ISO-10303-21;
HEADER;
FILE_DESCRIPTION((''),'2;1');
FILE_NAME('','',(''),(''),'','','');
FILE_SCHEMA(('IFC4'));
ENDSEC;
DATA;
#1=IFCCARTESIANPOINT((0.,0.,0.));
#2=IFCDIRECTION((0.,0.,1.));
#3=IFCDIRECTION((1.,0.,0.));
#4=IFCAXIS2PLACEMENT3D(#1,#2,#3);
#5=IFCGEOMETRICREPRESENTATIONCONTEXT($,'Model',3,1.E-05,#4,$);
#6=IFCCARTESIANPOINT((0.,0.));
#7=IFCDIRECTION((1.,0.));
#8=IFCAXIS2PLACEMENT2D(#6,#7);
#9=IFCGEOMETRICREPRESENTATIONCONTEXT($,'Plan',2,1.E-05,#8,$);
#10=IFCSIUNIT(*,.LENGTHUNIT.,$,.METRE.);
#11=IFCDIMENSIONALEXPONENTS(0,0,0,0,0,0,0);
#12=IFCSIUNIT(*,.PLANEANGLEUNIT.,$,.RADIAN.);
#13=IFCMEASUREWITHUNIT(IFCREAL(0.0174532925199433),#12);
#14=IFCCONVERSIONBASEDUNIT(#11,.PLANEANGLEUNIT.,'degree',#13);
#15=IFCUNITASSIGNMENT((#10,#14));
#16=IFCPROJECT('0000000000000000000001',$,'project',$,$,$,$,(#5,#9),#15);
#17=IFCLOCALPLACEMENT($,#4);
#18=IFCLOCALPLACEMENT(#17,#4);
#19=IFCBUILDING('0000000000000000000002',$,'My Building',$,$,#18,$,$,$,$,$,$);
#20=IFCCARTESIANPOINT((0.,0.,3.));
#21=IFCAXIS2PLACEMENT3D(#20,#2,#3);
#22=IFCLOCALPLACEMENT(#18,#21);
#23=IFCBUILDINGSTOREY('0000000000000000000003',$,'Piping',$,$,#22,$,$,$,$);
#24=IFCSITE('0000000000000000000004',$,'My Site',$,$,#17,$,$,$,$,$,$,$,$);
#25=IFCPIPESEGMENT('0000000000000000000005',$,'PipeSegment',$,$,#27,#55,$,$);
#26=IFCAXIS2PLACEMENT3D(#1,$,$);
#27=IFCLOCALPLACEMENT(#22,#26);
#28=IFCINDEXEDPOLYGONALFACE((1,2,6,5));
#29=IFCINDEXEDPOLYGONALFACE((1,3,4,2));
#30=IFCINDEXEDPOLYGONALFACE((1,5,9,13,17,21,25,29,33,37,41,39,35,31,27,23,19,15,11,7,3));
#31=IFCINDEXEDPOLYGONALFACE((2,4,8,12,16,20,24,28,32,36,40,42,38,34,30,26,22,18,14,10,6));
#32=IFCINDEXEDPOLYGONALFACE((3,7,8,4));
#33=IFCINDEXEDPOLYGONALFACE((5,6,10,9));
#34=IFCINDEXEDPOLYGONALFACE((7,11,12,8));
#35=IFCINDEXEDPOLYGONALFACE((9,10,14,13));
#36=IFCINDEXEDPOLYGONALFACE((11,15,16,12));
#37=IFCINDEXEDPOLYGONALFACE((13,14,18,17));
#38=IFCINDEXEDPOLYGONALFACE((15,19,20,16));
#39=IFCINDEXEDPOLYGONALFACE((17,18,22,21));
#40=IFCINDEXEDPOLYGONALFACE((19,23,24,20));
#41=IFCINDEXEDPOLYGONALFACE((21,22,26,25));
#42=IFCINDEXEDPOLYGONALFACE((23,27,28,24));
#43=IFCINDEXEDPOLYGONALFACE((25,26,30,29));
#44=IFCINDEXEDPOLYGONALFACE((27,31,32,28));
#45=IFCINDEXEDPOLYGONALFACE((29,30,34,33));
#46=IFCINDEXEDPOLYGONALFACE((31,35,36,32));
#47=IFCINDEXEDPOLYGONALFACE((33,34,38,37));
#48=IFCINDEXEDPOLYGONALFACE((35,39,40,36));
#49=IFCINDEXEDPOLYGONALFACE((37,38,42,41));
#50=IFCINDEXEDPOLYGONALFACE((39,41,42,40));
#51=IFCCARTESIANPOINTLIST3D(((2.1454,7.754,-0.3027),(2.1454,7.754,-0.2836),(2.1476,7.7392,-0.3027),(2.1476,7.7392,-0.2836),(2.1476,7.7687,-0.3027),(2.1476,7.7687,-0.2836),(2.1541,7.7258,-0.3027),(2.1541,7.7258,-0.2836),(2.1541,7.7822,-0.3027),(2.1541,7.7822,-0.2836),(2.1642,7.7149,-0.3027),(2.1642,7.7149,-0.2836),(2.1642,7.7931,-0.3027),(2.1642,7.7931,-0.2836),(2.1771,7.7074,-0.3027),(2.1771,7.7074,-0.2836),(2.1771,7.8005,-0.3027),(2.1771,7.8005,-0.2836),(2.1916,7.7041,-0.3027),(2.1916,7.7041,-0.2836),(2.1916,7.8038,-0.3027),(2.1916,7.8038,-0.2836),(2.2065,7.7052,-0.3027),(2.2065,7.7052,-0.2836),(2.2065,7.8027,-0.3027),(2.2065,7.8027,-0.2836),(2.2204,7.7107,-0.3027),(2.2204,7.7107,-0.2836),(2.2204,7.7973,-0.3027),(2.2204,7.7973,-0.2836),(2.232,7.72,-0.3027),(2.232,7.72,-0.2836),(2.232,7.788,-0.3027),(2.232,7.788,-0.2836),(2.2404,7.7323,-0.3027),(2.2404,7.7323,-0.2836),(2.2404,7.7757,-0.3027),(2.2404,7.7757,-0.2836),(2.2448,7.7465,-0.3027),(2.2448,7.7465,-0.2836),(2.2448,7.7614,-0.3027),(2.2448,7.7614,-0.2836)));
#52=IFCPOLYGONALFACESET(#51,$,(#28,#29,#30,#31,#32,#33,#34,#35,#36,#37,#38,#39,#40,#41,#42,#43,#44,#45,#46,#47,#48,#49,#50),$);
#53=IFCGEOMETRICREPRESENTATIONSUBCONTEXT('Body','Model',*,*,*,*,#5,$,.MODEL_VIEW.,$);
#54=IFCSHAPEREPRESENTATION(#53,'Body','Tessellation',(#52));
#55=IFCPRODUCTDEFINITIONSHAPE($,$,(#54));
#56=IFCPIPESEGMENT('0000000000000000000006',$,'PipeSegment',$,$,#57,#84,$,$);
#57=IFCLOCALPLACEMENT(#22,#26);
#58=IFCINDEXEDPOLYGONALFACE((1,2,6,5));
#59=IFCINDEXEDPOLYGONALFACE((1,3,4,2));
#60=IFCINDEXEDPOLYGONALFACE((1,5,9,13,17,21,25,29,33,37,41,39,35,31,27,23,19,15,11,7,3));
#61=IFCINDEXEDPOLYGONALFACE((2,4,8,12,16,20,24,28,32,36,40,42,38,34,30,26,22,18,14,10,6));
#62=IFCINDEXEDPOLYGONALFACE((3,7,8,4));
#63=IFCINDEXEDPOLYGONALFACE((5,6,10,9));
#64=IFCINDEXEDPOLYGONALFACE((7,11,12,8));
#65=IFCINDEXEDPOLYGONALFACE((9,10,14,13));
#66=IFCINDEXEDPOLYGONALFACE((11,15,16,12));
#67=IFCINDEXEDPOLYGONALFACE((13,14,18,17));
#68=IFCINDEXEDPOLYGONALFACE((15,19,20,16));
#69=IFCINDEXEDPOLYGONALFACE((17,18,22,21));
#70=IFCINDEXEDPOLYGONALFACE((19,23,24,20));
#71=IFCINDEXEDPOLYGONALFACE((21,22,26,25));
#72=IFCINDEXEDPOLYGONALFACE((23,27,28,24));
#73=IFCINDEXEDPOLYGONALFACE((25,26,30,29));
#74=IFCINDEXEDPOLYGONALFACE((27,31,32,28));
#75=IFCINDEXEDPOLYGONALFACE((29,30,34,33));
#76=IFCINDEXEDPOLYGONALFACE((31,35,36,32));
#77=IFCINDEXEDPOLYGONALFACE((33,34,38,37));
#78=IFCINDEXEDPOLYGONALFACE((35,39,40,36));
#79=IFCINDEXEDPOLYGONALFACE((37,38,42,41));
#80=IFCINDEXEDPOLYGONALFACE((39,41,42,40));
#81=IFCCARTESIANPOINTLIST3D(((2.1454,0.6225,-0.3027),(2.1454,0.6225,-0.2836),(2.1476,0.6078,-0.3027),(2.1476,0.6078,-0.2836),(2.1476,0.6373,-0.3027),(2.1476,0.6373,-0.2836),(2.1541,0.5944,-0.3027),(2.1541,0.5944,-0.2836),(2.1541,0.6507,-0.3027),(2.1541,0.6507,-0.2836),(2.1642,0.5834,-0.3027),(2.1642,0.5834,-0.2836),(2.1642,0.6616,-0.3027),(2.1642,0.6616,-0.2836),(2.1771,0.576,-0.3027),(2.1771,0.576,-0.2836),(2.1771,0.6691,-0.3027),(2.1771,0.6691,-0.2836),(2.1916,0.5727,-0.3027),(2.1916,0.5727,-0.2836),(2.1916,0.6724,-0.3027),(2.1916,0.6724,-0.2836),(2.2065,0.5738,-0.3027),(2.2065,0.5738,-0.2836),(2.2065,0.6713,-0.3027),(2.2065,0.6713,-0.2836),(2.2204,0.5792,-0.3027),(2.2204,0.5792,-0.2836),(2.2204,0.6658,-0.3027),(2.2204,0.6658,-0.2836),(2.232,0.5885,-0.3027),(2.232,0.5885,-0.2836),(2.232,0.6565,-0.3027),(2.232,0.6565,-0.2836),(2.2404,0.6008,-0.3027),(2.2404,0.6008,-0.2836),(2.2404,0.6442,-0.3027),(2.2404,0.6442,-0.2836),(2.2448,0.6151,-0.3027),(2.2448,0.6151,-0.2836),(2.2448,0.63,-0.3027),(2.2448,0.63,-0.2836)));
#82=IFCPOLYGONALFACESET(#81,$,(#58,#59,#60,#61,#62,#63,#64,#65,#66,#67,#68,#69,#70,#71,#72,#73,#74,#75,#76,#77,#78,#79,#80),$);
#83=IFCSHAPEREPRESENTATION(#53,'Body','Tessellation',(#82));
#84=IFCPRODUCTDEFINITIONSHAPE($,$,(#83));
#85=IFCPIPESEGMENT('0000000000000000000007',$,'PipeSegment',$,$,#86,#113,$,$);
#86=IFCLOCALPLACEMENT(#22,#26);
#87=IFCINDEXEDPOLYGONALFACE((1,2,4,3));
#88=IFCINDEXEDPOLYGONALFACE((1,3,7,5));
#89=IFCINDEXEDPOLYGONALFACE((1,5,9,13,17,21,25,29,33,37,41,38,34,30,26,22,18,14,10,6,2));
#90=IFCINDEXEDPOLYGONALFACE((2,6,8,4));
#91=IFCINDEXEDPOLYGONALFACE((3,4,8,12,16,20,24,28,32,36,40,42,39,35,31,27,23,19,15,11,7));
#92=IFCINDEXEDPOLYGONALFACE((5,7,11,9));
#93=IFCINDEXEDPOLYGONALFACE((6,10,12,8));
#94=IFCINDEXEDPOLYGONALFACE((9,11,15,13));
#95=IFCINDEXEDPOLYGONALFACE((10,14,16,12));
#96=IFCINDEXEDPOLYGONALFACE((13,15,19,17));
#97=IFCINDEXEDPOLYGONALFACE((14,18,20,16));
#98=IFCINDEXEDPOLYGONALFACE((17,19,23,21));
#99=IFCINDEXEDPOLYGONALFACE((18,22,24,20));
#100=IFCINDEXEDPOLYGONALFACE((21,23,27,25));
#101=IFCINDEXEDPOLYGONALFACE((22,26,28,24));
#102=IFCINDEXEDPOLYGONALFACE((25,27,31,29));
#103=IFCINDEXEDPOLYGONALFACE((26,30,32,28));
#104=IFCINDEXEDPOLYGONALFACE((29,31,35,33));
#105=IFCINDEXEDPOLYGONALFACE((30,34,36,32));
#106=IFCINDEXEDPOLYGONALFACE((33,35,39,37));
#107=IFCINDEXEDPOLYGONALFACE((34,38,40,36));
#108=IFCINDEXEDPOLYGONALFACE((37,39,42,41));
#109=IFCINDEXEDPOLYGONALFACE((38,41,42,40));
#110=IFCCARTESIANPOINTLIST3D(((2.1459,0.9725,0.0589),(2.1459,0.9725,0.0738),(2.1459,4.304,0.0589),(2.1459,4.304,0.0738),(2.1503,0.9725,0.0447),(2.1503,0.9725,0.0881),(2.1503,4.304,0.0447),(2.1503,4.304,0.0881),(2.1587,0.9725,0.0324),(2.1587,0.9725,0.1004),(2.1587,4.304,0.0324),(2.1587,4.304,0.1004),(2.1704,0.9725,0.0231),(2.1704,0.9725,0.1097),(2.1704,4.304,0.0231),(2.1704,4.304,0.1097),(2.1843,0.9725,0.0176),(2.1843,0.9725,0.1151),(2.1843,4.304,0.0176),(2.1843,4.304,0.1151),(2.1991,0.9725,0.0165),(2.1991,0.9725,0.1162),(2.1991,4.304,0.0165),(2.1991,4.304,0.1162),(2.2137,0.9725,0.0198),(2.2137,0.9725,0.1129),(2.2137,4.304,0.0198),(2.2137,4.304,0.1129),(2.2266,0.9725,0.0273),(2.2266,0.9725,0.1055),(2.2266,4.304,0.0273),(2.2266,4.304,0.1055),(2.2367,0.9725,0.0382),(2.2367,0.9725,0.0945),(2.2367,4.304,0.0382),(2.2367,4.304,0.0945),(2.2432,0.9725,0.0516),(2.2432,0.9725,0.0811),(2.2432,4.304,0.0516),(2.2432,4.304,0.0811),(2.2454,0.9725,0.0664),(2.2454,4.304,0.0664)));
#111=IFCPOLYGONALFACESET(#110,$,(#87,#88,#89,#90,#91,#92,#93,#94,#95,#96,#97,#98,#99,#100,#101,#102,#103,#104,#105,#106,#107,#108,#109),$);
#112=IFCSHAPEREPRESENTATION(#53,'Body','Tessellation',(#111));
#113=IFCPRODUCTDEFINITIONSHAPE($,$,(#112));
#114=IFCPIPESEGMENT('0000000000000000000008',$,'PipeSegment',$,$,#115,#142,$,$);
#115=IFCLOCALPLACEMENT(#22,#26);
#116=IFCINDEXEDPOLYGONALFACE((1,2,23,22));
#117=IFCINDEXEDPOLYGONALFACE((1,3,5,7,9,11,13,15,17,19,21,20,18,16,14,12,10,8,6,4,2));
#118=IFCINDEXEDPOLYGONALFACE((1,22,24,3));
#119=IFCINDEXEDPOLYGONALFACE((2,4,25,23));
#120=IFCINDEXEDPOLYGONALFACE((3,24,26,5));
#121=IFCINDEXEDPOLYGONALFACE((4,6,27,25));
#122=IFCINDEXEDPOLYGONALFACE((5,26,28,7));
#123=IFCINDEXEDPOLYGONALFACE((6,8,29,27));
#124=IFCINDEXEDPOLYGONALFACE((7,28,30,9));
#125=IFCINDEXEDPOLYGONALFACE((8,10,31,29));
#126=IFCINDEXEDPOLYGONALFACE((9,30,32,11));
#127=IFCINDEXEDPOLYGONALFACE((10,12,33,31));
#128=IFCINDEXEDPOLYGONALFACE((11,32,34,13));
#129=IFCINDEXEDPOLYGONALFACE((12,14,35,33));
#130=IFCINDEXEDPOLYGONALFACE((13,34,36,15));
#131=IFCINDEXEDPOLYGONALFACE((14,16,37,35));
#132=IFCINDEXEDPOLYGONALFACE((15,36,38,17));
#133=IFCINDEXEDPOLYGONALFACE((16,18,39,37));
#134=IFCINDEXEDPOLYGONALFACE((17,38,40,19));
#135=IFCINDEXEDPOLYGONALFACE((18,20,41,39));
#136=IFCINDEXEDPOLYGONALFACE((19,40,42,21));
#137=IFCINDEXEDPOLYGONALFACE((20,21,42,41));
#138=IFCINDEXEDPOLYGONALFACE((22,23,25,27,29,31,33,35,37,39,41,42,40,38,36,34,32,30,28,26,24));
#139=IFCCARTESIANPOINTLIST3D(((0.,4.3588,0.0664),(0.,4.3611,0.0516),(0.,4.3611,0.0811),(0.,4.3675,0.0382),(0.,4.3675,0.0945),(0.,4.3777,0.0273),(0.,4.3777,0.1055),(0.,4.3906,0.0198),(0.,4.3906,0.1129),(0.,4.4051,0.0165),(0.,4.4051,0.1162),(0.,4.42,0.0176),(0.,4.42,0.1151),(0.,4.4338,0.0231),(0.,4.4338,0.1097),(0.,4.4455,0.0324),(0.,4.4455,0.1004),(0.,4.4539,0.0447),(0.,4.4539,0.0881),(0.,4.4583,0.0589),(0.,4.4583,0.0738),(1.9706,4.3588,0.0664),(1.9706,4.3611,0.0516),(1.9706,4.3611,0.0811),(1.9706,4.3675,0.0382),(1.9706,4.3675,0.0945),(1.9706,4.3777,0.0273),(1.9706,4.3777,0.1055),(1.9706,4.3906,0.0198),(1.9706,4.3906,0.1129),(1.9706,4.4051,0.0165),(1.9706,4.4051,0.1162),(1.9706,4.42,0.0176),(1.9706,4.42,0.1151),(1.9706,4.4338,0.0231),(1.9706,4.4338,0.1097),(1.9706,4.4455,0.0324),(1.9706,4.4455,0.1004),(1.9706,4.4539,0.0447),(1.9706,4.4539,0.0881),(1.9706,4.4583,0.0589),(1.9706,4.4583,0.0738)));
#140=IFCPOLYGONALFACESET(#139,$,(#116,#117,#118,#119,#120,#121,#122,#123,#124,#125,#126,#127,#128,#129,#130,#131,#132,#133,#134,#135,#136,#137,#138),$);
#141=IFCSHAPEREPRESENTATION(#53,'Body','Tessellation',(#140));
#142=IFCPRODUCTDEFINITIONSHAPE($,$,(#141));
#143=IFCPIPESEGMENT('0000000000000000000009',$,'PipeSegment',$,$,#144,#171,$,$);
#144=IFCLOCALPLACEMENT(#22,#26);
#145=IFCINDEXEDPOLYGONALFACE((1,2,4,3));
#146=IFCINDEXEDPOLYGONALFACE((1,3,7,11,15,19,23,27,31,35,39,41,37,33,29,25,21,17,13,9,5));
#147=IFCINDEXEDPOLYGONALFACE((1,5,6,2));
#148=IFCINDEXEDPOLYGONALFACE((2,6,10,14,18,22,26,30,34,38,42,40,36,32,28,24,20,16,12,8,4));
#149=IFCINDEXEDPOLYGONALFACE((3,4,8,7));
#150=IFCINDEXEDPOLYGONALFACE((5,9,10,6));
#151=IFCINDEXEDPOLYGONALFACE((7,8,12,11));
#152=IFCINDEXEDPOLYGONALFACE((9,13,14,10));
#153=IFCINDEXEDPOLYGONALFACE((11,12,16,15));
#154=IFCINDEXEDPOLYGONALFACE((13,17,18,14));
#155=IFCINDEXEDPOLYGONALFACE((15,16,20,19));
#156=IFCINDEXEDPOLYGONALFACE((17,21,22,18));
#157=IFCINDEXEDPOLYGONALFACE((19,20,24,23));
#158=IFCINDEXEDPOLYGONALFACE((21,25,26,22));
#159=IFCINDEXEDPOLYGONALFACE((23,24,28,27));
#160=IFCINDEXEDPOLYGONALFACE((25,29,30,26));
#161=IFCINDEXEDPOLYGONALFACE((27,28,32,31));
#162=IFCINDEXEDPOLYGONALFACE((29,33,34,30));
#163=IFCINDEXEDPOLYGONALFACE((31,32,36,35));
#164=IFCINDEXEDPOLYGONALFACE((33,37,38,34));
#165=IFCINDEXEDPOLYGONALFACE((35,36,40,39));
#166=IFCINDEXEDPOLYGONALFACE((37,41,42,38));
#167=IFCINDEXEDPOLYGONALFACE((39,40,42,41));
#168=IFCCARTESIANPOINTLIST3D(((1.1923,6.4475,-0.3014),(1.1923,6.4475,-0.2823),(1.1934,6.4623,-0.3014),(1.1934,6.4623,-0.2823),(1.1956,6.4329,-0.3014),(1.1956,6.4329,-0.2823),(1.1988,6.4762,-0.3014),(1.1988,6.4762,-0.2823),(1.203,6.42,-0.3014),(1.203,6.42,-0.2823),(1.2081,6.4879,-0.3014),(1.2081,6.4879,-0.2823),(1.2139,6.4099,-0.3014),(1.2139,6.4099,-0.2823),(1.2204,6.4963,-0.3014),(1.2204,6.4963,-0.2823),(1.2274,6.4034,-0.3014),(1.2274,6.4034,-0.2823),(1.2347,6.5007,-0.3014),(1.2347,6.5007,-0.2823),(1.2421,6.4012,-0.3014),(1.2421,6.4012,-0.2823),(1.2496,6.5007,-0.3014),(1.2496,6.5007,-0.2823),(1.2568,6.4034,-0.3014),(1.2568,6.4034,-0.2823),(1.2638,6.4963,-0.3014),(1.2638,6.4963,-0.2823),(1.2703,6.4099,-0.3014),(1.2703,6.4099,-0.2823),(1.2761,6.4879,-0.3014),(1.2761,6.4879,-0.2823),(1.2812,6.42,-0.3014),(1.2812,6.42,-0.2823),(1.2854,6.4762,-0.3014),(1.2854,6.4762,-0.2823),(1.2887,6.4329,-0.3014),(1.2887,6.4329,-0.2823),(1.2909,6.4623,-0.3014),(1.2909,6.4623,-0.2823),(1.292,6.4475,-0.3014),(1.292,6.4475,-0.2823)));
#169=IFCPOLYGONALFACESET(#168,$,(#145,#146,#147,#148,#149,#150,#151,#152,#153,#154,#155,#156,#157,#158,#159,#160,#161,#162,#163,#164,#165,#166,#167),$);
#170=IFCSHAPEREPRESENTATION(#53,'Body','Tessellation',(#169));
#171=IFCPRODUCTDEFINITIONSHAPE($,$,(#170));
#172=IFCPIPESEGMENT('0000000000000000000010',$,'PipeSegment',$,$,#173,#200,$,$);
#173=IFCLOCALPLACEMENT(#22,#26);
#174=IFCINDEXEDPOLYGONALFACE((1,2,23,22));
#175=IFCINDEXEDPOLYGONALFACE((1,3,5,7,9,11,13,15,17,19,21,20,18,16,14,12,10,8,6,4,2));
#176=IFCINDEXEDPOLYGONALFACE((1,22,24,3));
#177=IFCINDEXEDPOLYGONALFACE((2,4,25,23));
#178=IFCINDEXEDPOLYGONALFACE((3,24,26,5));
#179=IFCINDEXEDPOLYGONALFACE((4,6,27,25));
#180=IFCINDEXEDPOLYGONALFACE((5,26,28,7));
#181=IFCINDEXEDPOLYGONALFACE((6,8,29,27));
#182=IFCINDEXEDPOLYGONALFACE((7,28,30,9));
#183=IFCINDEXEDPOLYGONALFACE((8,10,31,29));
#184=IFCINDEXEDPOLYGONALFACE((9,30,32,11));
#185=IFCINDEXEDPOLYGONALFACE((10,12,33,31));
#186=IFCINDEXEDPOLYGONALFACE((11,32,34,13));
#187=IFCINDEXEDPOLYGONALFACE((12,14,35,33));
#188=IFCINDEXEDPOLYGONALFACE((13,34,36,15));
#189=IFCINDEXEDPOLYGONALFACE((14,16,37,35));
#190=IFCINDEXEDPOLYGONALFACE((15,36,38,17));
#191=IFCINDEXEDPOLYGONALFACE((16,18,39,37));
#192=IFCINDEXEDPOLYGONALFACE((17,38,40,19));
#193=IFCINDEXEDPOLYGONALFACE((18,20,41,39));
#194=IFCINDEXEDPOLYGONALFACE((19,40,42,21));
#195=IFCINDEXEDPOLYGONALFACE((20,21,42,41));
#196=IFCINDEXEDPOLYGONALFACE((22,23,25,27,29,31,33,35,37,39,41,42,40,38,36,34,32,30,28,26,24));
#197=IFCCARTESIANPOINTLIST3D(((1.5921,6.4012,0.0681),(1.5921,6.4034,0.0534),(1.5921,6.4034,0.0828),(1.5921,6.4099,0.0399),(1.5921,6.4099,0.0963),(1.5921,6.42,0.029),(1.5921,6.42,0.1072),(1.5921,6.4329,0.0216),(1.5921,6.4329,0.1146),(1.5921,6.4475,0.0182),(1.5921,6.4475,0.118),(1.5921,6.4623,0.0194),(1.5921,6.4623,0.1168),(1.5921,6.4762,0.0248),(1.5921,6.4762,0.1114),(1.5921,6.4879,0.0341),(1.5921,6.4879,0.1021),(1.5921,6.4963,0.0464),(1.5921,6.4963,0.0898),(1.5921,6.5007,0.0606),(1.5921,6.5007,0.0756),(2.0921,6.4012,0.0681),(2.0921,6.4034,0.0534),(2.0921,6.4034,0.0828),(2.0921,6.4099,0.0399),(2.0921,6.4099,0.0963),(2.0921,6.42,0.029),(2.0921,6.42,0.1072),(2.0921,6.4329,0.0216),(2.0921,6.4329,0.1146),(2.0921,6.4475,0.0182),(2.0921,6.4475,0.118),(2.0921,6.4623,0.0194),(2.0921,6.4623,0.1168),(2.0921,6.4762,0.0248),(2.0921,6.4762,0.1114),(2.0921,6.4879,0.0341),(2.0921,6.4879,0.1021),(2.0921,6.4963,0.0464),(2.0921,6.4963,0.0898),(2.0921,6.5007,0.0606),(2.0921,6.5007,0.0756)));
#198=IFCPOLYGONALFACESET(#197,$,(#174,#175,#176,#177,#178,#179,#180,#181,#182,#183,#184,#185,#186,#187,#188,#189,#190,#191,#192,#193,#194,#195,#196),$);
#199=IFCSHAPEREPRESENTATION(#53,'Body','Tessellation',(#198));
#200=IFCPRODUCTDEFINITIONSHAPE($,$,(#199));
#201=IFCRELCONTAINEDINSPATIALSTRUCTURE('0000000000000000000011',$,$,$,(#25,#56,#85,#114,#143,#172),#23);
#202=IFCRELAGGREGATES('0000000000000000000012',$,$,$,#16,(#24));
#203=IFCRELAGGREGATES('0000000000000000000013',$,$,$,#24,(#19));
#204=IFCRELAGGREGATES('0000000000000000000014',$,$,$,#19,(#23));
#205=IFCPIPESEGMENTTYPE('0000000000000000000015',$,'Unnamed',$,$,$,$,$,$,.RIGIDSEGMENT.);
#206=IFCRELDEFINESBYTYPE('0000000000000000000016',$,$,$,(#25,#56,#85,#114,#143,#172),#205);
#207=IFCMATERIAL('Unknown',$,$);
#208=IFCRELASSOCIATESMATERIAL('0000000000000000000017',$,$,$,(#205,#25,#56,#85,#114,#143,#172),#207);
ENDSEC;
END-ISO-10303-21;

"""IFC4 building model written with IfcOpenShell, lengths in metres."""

from ifc_helpers import new_model, entity, si_unit, converted_unit, frame, origin_with_axes, origin_2d_with_axis, place, context, subcontext, project, spatial, circle, extrude, material, material_profile, profile_set, profile_usage, type_object, element, save


model = new_model("IFC4")

# Units and contexts
model_context = context("Model", 3, precision=1e-05, world=origin_with_axes())
plan_context = context("Plan", 2, precision=1e-05, world=origin_2d_with_axis())
body_context = subcontext(model_context, "Body", "Model", "MODEL_VIEW")
ifc_project = project(units=[si_unit("LENGTHUNIT", "METRE"), converted_unit("PLANEANGLEUNIT", "degree", entity("IfcReal", 0.0174532925199433), si_unit("PLANEANGLEUNIT", "RADIAN"), dimensions=[0, 0, 0, 0, 0, 0, 0])], contexts=[model_context, plan_context])

# Site, building, storey
site_placement = place(None, origin_with_axes())
site = spatial("IfcSite", under=ifc_project, at=site_placement, Name="My Site")
building_placement = place(site_placement, origin_with_axes())
building = spatial("IfcBuilding", under=site, at=building_placement, Name="My Building")
storey_placement = place(building_placement, frame((0.0, 0.0, 3.0), z_axis=(0.0, 0.0, 1.0), x_axis=(1.0, 0.0, 0.0)))
storey = spatial("IfcBuildingStorey", under=building, at=storey_placement, Name="Piping")

# Pipe segments
ifc_material = material(Name="Unknown")
ifc_material_profile_1 = material_profile(ifc_material, circle(Radius=0.05))
ifc_profile_set_1 = profile_set([ifc_material_profile_1])
pipe_segment_type = type_object("IfcPipeSegmentType", Name="Unnamed", PredefinedType="RIGIDSEGMENT", material=ifc_profile_set_1)
ifc_profile_usage_1 = profile_usage(ifc_profile_set_1, cardinal=5)
pipe_segment_1_placement = place(storey_placement, frame((2.1954, 7.754, -0.2836), z_axis=(0.0, 0.0, -1.0), x_axis=(-1.0, 0.0, 0.0)))
element("IfcPipeSegment", 1, at=pipe_segment_1_placement, inside=storey, type_object=pipe_segment_type, material=ifc_profile_usage_1, Name="PipeSegment", context=body_context, shape_type="SweptSolid", body=[
    extrude(circle(Radius=0.05), origin_with_axes(), (0.0, 0.0, 1.0), 0.0191),
])
ifc_profile_usage_2 = profile_usage(ifc_profile_set_1, cardinal=5)
pipe_segment_2_placement = place(storey_placement, frame((2.1954, 0.6225, -0.2836), z_axis=(0.0, 0.0, -1.0), x_axis=(-1.0, 0.0, 0.0)))
element("IfcPipeSegment", 2, at=pipe_segment_2_placement, inside=storey, type_object=pipe_segment_type, material=ifc_profile_usage_2, Name="PipeSegment", context=body_context, shape_type="SweptSolid", body=[
    extrude(circle(Radius=0.05), origin_with_axes(), (0.0, 0.0, 1.0), 0.0191),
])
ifc_profile_usage_3 = profile_usage(ifc_profile_set_1, cardinal=5)
pipe_segment_3_placement = place(storey_placement, frame((2.1954, 4.304, 0.0664), z_axis=(0.0, -1.0, 0.000002), x_axis=(1.0, 0.0, 0.0)))
element("IfcPipeSegment", 3, at=pipe_segment_3_placement, inside=storey, type_object=pipe_segment_type, material=ifc_profile_usage_3, Name="PipeSegment", context=body_context, shape_type="SweptSolid", body=[
    extrude(circle(Radius=0.05), origin_with_axes(), (0.0, 0.0, 1.0), 3.3315),
])
ifc_profile_usage_4 = profile_usage(ifc_profile_set_1, cardinal=5)
pipe_segment_4_placement = place(storey_placement, frame((1.9706, 4.4088, 0.0664), z_axis=(-1.0, 0.0, 0.0), x_axis=(0.0, -1.0, 0.0)))
element("IfcPipeSegment", 4, at=pipe_segment_4_placement, inside=storey, type_object=pipe_segment_type, material=ifc_profile_usage_4, Name="PipeSegment", context=body_context, shape_type="SweptSolid", body=[
    extrude(circle(Radius=0.05), origin_with_axes(), (0.0, 0.0, 1.0), 1.9706),
])
ifc_profile_usage_5 = profile_usage(ifc_profile_set_1, cardinal=5)
pipe_segment_5_placement = place(storey_placement, frame((1.2421, 6.4512, -0.2823), z_axis=(0.0, 0.0, -1.0), x_axis=(0.0, -1.0, 0.0)))
element("IfcPipeSegment", 5, at=pipe_segment_5_placement, inside=storey, type_object=pipe_segment_type, material=ifc_profile_usage_5, Name="PipeSegment", context=body_context, shape_type="SweptSolid", body=[
    extrude(circle(Radius=0.05), origin_with_axes(), (0.0, 0.0, 1.0), 0.0191),
])
ifc_profile_usage_6 = profile_usage(ifc_profile_set_1, cardinal=5)
pipe_segment_6_placement = place(storey_placement, frame((2.0921, 6.4512, 0.0681), z_axis=(-1.0, 0.0, 0.0), x_axis=(0.0, -1.0, 0.0)))
element("IfcPipeSegment", 6, at=pipe_segment_6_placement, inside=storey, type_object=pipe_segment_type, material=ifc_profile_usage_6, Name="PipeSegment", context=body_context, shape_type="SweptSolid", body=[
    extrude(circle(Radius=0.05), origin_with_axes(), (0.0, 0.0, 1.0), 0.5),
])

save(model, "model.ifc")
